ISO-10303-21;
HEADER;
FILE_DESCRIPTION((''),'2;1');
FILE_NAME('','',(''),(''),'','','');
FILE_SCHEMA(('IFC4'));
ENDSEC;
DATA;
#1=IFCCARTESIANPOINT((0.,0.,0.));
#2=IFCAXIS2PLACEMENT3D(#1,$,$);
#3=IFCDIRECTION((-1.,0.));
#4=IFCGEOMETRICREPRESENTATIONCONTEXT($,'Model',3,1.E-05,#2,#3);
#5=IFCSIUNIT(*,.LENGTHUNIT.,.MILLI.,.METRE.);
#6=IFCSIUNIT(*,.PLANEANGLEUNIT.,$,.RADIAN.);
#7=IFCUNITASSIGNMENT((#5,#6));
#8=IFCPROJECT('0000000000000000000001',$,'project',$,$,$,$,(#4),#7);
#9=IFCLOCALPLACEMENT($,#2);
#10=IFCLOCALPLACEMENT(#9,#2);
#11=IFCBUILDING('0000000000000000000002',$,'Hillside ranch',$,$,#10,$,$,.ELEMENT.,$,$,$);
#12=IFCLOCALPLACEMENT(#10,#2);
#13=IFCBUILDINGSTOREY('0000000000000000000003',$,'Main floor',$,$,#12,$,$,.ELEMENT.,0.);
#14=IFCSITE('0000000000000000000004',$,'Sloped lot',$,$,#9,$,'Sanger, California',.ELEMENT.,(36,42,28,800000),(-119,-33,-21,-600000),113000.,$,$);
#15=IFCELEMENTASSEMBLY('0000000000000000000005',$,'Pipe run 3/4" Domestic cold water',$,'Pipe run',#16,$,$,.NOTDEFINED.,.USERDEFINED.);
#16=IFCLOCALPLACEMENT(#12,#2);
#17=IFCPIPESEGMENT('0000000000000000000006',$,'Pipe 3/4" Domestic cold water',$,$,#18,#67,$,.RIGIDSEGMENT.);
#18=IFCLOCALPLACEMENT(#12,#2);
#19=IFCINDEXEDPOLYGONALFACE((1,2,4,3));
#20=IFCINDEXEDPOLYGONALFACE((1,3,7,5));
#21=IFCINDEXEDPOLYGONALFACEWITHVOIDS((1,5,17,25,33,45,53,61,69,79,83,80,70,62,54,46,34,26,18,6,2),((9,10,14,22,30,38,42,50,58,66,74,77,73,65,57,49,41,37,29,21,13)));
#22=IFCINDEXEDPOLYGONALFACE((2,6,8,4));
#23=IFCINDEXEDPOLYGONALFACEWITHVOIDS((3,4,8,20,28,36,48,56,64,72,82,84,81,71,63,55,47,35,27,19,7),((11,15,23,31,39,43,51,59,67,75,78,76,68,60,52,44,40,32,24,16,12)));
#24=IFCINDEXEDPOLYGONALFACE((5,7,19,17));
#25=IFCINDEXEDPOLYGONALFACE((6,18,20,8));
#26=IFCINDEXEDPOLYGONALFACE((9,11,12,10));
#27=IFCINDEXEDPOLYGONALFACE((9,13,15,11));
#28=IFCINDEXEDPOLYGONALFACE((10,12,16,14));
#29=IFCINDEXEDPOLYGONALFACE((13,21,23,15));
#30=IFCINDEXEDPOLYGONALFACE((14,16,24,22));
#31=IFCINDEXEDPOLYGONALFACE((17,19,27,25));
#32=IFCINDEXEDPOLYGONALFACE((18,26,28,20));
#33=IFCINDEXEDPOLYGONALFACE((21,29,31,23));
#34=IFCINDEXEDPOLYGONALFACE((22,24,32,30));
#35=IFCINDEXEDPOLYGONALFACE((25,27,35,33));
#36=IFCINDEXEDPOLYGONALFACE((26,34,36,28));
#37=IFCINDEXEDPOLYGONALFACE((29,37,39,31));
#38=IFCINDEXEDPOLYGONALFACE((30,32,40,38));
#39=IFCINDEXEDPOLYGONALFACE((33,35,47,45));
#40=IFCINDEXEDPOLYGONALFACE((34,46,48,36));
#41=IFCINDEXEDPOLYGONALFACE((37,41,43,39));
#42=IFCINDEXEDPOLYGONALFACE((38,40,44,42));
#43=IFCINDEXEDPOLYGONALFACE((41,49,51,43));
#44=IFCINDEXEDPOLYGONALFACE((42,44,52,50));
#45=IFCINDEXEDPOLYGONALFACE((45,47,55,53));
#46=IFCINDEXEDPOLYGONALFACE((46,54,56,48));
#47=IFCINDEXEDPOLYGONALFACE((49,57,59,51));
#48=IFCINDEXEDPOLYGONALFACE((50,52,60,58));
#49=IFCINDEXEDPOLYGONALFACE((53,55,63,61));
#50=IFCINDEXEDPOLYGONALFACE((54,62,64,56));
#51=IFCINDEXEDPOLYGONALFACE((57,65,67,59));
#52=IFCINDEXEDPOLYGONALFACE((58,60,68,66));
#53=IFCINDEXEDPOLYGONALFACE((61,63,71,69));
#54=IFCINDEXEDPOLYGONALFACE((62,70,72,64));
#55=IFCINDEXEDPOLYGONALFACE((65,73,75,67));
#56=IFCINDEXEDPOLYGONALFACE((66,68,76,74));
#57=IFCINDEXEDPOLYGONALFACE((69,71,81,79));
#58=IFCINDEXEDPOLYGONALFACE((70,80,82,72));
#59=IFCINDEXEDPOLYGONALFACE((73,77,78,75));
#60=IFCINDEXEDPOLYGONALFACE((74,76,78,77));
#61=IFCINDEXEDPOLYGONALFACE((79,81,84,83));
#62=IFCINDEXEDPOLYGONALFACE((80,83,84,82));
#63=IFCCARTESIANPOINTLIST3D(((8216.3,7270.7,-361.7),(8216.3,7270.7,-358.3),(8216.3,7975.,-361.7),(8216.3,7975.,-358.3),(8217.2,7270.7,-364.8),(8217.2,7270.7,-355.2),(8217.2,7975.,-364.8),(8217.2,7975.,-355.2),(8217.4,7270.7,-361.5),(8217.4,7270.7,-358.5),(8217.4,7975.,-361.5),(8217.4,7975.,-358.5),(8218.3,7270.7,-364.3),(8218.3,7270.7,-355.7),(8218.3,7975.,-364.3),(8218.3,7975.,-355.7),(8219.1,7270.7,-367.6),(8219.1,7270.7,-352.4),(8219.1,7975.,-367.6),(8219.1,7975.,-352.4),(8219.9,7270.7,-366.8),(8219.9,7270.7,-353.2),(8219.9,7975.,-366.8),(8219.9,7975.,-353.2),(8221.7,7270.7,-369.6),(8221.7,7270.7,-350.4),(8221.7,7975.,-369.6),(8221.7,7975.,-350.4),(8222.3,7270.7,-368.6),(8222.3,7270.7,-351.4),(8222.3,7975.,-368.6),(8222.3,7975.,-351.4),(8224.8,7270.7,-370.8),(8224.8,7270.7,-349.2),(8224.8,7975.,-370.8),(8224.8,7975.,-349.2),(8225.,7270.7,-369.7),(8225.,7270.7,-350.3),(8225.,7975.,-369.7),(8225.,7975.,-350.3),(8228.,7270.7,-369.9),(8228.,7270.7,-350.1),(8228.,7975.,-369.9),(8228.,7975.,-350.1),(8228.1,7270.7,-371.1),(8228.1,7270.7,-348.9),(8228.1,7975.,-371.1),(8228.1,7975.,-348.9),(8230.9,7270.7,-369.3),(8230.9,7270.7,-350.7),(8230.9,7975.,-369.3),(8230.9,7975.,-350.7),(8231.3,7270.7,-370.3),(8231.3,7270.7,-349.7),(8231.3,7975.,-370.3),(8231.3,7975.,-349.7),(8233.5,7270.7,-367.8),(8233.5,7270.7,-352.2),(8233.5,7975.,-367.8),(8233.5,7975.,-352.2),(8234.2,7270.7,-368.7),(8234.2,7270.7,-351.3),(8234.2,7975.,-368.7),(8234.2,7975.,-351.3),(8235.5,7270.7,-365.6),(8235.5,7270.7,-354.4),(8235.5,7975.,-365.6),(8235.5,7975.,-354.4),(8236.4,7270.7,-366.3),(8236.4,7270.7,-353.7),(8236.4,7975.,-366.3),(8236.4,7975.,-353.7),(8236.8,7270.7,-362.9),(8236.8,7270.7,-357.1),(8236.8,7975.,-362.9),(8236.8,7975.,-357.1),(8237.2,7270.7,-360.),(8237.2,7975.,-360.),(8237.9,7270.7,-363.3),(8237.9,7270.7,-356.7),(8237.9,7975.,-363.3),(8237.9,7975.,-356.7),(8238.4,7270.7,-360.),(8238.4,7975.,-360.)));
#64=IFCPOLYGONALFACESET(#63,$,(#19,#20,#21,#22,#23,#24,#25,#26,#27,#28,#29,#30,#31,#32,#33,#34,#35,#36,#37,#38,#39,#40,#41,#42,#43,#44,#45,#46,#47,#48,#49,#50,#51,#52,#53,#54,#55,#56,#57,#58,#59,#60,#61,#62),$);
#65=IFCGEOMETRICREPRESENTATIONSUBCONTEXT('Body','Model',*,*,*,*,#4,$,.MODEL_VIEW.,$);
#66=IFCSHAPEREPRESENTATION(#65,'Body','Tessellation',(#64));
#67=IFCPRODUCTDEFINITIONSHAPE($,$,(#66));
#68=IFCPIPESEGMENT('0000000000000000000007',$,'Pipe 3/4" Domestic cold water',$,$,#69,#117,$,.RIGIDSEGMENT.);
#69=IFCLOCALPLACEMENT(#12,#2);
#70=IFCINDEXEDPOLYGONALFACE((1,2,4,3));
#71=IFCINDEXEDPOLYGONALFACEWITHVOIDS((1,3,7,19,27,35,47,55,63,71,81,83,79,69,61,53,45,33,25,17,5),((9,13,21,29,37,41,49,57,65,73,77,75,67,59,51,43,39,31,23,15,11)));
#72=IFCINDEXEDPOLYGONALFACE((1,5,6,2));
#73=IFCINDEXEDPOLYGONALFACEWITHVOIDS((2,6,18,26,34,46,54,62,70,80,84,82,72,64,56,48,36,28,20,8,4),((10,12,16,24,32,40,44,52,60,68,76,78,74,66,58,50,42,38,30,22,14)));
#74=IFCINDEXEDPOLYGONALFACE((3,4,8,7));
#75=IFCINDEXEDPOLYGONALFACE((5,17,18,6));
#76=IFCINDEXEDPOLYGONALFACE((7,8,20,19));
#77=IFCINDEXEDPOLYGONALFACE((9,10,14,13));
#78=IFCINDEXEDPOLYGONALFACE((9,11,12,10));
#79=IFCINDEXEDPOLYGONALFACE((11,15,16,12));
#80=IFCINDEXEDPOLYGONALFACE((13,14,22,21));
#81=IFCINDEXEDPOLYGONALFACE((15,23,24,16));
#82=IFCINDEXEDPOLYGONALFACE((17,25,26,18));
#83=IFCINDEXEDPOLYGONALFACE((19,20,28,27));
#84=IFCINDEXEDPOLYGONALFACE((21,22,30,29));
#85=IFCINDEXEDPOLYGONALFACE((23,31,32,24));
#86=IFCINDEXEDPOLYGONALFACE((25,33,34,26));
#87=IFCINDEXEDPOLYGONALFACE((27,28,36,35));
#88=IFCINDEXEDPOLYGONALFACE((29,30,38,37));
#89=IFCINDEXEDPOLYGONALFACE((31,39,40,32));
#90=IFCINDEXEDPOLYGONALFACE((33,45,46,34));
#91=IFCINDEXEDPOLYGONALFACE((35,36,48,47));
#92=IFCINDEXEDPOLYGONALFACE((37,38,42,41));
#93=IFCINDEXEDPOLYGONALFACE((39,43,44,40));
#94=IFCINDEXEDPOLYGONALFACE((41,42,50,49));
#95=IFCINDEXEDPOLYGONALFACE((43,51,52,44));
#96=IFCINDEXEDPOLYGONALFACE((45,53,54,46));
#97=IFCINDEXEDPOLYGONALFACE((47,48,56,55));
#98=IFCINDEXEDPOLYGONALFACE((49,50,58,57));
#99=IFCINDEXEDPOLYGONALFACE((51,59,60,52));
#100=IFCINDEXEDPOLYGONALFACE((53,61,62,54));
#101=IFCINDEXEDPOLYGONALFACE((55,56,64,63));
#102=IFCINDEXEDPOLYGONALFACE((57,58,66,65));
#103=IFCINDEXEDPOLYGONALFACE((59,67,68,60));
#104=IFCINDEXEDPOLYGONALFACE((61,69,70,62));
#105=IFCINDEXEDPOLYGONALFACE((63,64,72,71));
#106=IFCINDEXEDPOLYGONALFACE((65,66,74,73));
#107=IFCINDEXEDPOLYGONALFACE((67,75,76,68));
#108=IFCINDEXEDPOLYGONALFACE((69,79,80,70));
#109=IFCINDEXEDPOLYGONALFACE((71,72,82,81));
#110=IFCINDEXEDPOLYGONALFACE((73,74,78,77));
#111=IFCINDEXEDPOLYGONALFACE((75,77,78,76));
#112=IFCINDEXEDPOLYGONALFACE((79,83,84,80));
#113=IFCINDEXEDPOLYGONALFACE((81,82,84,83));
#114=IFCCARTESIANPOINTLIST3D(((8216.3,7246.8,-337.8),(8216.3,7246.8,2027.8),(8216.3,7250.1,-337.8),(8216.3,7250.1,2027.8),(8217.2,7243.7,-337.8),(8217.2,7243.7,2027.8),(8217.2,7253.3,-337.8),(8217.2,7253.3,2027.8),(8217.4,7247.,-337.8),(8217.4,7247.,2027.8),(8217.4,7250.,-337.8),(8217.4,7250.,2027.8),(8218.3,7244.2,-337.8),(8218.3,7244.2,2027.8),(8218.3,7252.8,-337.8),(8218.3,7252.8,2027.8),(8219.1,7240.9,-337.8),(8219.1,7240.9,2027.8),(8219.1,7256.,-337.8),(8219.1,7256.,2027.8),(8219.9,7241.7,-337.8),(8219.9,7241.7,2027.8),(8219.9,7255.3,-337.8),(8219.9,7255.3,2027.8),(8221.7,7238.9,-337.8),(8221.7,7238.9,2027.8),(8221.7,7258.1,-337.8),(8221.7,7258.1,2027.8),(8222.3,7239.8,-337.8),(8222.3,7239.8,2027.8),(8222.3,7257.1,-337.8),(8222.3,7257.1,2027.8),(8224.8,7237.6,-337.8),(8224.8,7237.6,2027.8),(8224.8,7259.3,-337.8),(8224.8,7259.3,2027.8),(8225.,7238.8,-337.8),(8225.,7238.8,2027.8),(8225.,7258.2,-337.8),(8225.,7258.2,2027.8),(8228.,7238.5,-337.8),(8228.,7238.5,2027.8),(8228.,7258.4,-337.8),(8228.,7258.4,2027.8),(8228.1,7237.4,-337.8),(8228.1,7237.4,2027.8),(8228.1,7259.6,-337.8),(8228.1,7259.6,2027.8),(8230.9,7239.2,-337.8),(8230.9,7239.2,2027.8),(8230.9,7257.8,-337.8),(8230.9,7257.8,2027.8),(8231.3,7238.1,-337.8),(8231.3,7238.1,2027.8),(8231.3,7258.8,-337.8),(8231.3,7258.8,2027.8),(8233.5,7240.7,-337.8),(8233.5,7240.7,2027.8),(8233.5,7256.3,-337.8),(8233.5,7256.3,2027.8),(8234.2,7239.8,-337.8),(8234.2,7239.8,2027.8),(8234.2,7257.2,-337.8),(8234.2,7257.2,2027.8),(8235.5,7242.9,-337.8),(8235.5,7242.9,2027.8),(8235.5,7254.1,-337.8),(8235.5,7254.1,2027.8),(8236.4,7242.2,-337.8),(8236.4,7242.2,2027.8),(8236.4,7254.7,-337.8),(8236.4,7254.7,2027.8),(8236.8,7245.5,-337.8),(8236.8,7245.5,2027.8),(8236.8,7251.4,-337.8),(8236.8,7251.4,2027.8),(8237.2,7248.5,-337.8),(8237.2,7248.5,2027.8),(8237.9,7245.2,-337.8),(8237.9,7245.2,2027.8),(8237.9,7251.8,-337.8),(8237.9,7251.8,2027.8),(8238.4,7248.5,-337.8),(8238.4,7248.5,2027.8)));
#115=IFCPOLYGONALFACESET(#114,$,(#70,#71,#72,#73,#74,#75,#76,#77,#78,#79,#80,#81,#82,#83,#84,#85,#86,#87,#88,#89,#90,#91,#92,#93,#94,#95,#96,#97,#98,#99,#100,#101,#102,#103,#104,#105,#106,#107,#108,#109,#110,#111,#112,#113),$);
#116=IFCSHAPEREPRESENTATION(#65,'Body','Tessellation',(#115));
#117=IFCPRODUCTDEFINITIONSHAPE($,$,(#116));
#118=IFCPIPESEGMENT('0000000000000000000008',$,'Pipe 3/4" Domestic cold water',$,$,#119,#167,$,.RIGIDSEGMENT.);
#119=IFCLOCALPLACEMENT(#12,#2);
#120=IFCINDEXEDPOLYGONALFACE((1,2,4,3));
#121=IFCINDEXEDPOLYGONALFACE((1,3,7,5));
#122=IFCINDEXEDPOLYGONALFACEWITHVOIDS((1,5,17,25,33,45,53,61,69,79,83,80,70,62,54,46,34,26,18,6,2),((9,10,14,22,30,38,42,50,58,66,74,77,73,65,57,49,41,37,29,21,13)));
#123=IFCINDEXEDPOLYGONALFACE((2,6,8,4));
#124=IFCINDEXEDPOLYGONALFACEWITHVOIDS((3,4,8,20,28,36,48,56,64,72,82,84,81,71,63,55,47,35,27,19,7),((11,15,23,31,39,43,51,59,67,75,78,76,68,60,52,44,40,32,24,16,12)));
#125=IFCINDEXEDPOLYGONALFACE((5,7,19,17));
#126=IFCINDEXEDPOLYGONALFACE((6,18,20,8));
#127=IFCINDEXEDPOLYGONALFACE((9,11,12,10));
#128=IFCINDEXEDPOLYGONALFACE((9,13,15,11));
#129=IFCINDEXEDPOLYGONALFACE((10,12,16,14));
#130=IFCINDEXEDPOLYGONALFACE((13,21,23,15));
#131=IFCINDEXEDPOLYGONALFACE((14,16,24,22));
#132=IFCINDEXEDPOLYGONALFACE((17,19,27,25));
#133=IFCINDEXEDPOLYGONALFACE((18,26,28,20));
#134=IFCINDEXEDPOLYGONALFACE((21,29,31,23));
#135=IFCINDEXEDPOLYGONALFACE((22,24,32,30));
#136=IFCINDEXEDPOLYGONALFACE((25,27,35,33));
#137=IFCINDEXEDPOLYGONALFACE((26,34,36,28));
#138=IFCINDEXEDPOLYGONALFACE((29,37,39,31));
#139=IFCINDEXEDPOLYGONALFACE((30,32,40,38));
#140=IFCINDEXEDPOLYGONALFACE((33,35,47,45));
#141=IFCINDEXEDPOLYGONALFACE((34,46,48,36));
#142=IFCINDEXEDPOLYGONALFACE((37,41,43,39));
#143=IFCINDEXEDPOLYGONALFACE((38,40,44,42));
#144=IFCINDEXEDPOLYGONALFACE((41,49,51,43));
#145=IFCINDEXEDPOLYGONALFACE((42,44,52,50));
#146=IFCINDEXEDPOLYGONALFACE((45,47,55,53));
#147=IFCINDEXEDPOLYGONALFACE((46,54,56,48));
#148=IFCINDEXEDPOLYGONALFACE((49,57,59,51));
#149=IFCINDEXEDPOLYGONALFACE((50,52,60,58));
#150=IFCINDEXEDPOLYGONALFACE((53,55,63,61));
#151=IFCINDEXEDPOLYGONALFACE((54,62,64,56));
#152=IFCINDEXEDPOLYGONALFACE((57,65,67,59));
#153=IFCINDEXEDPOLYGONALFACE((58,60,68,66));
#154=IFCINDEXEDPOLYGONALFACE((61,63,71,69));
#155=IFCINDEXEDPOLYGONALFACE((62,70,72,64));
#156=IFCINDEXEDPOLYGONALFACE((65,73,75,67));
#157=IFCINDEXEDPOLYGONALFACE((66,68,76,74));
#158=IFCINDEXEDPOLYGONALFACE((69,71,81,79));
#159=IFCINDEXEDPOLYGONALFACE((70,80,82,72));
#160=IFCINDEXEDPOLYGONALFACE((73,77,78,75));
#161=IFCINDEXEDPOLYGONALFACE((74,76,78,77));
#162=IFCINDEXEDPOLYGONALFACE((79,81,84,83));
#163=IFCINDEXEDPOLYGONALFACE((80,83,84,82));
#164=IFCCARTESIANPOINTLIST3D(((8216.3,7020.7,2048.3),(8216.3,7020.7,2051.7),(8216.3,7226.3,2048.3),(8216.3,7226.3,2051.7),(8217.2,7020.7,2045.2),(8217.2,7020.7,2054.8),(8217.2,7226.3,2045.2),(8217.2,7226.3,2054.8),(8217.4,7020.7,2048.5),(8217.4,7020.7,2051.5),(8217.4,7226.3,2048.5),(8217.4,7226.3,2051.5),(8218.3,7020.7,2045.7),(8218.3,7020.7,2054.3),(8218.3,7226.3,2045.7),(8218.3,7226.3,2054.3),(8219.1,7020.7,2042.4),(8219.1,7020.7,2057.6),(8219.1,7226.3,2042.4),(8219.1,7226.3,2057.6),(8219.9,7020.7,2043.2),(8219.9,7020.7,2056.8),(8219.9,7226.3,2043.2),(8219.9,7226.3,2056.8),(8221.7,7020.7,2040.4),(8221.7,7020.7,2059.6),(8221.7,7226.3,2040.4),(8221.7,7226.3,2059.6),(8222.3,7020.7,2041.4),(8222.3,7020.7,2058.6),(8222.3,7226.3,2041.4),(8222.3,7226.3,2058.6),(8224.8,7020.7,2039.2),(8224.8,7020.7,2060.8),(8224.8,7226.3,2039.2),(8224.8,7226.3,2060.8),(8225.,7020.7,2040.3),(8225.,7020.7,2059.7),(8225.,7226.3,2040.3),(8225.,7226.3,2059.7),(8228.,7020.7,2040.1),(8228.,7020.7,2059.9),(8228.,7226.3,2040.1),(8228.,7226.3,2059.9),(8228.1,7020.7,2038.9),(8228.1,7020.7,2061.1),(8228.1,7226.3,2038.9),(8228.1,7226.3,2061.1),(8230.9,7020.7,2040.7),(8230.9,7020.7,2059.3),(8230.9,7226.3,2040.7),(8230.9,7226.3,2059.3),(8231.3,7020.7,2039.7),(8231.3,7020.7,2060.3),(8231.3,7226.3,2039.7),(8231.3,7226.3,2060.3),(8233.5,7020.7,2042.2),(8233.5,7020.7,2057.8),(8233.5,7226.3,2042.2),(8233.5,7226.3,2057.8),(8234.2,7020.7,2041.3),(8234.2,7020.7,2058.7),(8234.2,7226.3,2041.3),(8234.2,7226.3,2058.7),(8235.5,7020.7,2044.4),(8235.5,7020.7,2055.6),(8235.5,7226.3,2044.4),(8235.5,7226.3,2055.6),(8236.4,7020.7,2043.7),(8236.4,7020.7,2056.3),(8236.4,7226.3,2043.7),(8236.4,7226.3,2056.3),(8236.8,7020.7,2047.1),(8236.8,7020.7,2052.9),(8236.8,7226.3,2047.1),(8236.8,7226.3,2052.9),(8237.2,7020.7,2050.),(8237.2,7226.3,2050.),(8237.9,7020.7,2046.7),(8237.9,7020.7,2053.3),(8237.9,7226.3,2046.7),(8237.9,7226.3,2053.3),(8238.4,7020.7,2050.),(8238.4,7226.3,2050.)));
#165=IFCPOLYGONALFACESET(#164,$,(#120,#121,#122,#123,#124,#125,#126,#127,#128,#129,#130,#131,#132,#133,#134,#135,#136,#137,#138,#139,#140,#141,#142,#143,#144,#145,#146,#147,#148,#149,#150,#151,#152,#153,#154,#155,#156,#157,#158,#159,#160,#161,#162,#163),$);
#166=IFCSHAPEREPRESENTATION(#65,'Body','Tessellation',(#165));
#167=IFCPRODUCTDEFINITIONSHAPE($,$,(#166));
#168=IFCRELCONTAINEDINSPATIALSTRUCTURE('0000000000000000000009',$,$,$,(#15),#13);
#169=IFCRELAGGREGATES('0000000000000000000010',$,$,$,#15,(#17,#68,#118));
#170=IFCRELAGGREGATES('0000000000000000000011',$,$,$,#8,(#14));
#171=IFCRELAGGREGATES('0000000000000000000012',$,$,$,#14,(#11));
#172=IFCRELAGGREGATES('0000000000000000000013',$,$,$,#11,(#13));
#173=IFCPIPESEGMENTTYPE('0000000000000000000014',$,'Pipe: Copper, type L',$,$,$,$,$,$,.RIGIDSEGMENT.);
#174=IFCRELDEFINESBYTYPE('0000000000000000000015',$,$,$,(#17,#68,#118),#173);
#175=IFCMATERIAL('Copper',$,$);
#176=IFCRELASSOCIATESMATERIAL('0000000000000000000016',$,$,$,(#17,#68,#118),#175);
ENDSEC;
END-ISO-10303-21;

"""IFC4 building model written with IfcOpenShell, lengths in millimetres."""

from ifc_helpers import new_model, si_unit, direction, frame, origin, origin_with_axes, origin_2d, place, context, subcontext, project, spatial, hollow_circle, extrude, material, type_object, element, aggregate, save


model = new_model("IFC4")

# Units and contexts
model_context = context("Model", 3, precision=1e-05, world=origin(), true_north=direction((-1.0, 0.0)))
body_context = subcontext(model_context, "Body", "Model", "MODEL_VIEW")
ifc_project = project(units=[si_unit("LENGTHUNIT", "METRE", prefix="MILLI"), si_unit("PLANEANGLEUNIT", "RADIAN")], contexts=[model_context])

# Site, building, storey
site_placement = place(None, origin())
site = spatial("IfcSite", under=ifc_project, at=site_placement, Name="Sloped lot", LongName="Sanger, California", CompositionType="ELEMENT", RefLatitude=(36, 42, 28, 800000), RefLongitude=(-119, -33, -21, -600000), RefElevation=113000.0)
building_placement = place(site_placement, origin())
building = spatial("IfcBuilding", under=site, at=building_placement, Name="Hillside ranch", CompositionType="ELEMENT")
storey_placement = place(building_placement, origin())
storey = spatial("IfcBuildingStorey", under=building, at=storey_placement, Name="Main floor", CompositionType="ELEMENT", Elevation=0.0)

# Element assembly
ifc_material = material(Name="Copper")
assembly_1_placement = place(storey_placement, origin_with_axes())
assembly_1 = element("IfcElementAssembly", 1, at=assembly_1_placement, inside=storey, Name="Pipe run 3/4\" Domestic cold water", ObjectType="Pipe run", AssemblyPlace="NOTDEFINED", PredefinedType="USERDEFINED")

# Pipe segments
pipe_segment_type = type_object("IfcPipeSegmentType", Name="Pipe: Copper, type L", PredefinedType="RIGIDSEGMENT")
pipe_segment_1_placement = place(storey_placement, origin_with_axes())
pipe_segment_1 = element("IfcPipeSegment", 2, at=pipe_segment_1_placement, type_object=pipe_segment_type, material=ifc_material, Name="Pipe 3/4\" Domestic cold water", PredefinedType="RIGIDSEGMENT", context=body_context, shape_type="SweptSolid", body=[
    extrude(hollow_circle(Radius=11.1, WallThickness=1.1, at=origin_2d()), frame((8227.2, 7975.0, -360.0), z_axis=(0.0, -1.0, 0.0), x_axis=(1.0, 0.0, 0.0)), (0.0, 0.0, 1.0), 704.3),
])
pipe_segment_2_placement = place(storey_placement, origin_with_axes())
pipe_segment_2 = element("IfcPipeSegment", 3, at=pipe_segment_2_placement, type_object=pipe_segment_type, material=ifc_material, Name="Pipe 3/4\" Domestic cold water", PredefinedType="RIGIDSEGMENT", context=body_context, shape_type="SweptSolid", body=[
    extrude(hollow_circle(Radius=11.1, WallThickness=1.1, at=origin_2d()), frame((8227.2, 7248.5, -337.8), z_axis=(0.0, 0.0, 1.0), x_axis=(1.0, 0.0, 0.0)), (0.0, 0.0, 1.0), 2365.6),
])
pipe_segment_3_placement = place(storey_placement, origin_with_axes())
pipe_segment_3 = element("IfcPipeSegment", 4, at=pipe_segment_3_placement, type_object=pipe_segment_type, material=ifc_material, Name="Pipe 3/4\" Domestic cold water", PredefinedType="RIGIDSEGMENT", context=body_context, shape_type="SweptSolid", body=[
    extrude(hollow_circle(Radius=11.1, WallThickness=1.1, at=origin_2d()), frame((8227.2, 7226.3, 2050.0), z_axis=(0.0, -1.0, 0.0), x_axis=(1.0, 0.0, 0.0)), (0.0, 0.0, 1.0), 205.6),
])
aggregate(assembly_1, [pipe_segment_1, pipe_segment_2, pipe_segment_3])

save(model, "model.ifc")
